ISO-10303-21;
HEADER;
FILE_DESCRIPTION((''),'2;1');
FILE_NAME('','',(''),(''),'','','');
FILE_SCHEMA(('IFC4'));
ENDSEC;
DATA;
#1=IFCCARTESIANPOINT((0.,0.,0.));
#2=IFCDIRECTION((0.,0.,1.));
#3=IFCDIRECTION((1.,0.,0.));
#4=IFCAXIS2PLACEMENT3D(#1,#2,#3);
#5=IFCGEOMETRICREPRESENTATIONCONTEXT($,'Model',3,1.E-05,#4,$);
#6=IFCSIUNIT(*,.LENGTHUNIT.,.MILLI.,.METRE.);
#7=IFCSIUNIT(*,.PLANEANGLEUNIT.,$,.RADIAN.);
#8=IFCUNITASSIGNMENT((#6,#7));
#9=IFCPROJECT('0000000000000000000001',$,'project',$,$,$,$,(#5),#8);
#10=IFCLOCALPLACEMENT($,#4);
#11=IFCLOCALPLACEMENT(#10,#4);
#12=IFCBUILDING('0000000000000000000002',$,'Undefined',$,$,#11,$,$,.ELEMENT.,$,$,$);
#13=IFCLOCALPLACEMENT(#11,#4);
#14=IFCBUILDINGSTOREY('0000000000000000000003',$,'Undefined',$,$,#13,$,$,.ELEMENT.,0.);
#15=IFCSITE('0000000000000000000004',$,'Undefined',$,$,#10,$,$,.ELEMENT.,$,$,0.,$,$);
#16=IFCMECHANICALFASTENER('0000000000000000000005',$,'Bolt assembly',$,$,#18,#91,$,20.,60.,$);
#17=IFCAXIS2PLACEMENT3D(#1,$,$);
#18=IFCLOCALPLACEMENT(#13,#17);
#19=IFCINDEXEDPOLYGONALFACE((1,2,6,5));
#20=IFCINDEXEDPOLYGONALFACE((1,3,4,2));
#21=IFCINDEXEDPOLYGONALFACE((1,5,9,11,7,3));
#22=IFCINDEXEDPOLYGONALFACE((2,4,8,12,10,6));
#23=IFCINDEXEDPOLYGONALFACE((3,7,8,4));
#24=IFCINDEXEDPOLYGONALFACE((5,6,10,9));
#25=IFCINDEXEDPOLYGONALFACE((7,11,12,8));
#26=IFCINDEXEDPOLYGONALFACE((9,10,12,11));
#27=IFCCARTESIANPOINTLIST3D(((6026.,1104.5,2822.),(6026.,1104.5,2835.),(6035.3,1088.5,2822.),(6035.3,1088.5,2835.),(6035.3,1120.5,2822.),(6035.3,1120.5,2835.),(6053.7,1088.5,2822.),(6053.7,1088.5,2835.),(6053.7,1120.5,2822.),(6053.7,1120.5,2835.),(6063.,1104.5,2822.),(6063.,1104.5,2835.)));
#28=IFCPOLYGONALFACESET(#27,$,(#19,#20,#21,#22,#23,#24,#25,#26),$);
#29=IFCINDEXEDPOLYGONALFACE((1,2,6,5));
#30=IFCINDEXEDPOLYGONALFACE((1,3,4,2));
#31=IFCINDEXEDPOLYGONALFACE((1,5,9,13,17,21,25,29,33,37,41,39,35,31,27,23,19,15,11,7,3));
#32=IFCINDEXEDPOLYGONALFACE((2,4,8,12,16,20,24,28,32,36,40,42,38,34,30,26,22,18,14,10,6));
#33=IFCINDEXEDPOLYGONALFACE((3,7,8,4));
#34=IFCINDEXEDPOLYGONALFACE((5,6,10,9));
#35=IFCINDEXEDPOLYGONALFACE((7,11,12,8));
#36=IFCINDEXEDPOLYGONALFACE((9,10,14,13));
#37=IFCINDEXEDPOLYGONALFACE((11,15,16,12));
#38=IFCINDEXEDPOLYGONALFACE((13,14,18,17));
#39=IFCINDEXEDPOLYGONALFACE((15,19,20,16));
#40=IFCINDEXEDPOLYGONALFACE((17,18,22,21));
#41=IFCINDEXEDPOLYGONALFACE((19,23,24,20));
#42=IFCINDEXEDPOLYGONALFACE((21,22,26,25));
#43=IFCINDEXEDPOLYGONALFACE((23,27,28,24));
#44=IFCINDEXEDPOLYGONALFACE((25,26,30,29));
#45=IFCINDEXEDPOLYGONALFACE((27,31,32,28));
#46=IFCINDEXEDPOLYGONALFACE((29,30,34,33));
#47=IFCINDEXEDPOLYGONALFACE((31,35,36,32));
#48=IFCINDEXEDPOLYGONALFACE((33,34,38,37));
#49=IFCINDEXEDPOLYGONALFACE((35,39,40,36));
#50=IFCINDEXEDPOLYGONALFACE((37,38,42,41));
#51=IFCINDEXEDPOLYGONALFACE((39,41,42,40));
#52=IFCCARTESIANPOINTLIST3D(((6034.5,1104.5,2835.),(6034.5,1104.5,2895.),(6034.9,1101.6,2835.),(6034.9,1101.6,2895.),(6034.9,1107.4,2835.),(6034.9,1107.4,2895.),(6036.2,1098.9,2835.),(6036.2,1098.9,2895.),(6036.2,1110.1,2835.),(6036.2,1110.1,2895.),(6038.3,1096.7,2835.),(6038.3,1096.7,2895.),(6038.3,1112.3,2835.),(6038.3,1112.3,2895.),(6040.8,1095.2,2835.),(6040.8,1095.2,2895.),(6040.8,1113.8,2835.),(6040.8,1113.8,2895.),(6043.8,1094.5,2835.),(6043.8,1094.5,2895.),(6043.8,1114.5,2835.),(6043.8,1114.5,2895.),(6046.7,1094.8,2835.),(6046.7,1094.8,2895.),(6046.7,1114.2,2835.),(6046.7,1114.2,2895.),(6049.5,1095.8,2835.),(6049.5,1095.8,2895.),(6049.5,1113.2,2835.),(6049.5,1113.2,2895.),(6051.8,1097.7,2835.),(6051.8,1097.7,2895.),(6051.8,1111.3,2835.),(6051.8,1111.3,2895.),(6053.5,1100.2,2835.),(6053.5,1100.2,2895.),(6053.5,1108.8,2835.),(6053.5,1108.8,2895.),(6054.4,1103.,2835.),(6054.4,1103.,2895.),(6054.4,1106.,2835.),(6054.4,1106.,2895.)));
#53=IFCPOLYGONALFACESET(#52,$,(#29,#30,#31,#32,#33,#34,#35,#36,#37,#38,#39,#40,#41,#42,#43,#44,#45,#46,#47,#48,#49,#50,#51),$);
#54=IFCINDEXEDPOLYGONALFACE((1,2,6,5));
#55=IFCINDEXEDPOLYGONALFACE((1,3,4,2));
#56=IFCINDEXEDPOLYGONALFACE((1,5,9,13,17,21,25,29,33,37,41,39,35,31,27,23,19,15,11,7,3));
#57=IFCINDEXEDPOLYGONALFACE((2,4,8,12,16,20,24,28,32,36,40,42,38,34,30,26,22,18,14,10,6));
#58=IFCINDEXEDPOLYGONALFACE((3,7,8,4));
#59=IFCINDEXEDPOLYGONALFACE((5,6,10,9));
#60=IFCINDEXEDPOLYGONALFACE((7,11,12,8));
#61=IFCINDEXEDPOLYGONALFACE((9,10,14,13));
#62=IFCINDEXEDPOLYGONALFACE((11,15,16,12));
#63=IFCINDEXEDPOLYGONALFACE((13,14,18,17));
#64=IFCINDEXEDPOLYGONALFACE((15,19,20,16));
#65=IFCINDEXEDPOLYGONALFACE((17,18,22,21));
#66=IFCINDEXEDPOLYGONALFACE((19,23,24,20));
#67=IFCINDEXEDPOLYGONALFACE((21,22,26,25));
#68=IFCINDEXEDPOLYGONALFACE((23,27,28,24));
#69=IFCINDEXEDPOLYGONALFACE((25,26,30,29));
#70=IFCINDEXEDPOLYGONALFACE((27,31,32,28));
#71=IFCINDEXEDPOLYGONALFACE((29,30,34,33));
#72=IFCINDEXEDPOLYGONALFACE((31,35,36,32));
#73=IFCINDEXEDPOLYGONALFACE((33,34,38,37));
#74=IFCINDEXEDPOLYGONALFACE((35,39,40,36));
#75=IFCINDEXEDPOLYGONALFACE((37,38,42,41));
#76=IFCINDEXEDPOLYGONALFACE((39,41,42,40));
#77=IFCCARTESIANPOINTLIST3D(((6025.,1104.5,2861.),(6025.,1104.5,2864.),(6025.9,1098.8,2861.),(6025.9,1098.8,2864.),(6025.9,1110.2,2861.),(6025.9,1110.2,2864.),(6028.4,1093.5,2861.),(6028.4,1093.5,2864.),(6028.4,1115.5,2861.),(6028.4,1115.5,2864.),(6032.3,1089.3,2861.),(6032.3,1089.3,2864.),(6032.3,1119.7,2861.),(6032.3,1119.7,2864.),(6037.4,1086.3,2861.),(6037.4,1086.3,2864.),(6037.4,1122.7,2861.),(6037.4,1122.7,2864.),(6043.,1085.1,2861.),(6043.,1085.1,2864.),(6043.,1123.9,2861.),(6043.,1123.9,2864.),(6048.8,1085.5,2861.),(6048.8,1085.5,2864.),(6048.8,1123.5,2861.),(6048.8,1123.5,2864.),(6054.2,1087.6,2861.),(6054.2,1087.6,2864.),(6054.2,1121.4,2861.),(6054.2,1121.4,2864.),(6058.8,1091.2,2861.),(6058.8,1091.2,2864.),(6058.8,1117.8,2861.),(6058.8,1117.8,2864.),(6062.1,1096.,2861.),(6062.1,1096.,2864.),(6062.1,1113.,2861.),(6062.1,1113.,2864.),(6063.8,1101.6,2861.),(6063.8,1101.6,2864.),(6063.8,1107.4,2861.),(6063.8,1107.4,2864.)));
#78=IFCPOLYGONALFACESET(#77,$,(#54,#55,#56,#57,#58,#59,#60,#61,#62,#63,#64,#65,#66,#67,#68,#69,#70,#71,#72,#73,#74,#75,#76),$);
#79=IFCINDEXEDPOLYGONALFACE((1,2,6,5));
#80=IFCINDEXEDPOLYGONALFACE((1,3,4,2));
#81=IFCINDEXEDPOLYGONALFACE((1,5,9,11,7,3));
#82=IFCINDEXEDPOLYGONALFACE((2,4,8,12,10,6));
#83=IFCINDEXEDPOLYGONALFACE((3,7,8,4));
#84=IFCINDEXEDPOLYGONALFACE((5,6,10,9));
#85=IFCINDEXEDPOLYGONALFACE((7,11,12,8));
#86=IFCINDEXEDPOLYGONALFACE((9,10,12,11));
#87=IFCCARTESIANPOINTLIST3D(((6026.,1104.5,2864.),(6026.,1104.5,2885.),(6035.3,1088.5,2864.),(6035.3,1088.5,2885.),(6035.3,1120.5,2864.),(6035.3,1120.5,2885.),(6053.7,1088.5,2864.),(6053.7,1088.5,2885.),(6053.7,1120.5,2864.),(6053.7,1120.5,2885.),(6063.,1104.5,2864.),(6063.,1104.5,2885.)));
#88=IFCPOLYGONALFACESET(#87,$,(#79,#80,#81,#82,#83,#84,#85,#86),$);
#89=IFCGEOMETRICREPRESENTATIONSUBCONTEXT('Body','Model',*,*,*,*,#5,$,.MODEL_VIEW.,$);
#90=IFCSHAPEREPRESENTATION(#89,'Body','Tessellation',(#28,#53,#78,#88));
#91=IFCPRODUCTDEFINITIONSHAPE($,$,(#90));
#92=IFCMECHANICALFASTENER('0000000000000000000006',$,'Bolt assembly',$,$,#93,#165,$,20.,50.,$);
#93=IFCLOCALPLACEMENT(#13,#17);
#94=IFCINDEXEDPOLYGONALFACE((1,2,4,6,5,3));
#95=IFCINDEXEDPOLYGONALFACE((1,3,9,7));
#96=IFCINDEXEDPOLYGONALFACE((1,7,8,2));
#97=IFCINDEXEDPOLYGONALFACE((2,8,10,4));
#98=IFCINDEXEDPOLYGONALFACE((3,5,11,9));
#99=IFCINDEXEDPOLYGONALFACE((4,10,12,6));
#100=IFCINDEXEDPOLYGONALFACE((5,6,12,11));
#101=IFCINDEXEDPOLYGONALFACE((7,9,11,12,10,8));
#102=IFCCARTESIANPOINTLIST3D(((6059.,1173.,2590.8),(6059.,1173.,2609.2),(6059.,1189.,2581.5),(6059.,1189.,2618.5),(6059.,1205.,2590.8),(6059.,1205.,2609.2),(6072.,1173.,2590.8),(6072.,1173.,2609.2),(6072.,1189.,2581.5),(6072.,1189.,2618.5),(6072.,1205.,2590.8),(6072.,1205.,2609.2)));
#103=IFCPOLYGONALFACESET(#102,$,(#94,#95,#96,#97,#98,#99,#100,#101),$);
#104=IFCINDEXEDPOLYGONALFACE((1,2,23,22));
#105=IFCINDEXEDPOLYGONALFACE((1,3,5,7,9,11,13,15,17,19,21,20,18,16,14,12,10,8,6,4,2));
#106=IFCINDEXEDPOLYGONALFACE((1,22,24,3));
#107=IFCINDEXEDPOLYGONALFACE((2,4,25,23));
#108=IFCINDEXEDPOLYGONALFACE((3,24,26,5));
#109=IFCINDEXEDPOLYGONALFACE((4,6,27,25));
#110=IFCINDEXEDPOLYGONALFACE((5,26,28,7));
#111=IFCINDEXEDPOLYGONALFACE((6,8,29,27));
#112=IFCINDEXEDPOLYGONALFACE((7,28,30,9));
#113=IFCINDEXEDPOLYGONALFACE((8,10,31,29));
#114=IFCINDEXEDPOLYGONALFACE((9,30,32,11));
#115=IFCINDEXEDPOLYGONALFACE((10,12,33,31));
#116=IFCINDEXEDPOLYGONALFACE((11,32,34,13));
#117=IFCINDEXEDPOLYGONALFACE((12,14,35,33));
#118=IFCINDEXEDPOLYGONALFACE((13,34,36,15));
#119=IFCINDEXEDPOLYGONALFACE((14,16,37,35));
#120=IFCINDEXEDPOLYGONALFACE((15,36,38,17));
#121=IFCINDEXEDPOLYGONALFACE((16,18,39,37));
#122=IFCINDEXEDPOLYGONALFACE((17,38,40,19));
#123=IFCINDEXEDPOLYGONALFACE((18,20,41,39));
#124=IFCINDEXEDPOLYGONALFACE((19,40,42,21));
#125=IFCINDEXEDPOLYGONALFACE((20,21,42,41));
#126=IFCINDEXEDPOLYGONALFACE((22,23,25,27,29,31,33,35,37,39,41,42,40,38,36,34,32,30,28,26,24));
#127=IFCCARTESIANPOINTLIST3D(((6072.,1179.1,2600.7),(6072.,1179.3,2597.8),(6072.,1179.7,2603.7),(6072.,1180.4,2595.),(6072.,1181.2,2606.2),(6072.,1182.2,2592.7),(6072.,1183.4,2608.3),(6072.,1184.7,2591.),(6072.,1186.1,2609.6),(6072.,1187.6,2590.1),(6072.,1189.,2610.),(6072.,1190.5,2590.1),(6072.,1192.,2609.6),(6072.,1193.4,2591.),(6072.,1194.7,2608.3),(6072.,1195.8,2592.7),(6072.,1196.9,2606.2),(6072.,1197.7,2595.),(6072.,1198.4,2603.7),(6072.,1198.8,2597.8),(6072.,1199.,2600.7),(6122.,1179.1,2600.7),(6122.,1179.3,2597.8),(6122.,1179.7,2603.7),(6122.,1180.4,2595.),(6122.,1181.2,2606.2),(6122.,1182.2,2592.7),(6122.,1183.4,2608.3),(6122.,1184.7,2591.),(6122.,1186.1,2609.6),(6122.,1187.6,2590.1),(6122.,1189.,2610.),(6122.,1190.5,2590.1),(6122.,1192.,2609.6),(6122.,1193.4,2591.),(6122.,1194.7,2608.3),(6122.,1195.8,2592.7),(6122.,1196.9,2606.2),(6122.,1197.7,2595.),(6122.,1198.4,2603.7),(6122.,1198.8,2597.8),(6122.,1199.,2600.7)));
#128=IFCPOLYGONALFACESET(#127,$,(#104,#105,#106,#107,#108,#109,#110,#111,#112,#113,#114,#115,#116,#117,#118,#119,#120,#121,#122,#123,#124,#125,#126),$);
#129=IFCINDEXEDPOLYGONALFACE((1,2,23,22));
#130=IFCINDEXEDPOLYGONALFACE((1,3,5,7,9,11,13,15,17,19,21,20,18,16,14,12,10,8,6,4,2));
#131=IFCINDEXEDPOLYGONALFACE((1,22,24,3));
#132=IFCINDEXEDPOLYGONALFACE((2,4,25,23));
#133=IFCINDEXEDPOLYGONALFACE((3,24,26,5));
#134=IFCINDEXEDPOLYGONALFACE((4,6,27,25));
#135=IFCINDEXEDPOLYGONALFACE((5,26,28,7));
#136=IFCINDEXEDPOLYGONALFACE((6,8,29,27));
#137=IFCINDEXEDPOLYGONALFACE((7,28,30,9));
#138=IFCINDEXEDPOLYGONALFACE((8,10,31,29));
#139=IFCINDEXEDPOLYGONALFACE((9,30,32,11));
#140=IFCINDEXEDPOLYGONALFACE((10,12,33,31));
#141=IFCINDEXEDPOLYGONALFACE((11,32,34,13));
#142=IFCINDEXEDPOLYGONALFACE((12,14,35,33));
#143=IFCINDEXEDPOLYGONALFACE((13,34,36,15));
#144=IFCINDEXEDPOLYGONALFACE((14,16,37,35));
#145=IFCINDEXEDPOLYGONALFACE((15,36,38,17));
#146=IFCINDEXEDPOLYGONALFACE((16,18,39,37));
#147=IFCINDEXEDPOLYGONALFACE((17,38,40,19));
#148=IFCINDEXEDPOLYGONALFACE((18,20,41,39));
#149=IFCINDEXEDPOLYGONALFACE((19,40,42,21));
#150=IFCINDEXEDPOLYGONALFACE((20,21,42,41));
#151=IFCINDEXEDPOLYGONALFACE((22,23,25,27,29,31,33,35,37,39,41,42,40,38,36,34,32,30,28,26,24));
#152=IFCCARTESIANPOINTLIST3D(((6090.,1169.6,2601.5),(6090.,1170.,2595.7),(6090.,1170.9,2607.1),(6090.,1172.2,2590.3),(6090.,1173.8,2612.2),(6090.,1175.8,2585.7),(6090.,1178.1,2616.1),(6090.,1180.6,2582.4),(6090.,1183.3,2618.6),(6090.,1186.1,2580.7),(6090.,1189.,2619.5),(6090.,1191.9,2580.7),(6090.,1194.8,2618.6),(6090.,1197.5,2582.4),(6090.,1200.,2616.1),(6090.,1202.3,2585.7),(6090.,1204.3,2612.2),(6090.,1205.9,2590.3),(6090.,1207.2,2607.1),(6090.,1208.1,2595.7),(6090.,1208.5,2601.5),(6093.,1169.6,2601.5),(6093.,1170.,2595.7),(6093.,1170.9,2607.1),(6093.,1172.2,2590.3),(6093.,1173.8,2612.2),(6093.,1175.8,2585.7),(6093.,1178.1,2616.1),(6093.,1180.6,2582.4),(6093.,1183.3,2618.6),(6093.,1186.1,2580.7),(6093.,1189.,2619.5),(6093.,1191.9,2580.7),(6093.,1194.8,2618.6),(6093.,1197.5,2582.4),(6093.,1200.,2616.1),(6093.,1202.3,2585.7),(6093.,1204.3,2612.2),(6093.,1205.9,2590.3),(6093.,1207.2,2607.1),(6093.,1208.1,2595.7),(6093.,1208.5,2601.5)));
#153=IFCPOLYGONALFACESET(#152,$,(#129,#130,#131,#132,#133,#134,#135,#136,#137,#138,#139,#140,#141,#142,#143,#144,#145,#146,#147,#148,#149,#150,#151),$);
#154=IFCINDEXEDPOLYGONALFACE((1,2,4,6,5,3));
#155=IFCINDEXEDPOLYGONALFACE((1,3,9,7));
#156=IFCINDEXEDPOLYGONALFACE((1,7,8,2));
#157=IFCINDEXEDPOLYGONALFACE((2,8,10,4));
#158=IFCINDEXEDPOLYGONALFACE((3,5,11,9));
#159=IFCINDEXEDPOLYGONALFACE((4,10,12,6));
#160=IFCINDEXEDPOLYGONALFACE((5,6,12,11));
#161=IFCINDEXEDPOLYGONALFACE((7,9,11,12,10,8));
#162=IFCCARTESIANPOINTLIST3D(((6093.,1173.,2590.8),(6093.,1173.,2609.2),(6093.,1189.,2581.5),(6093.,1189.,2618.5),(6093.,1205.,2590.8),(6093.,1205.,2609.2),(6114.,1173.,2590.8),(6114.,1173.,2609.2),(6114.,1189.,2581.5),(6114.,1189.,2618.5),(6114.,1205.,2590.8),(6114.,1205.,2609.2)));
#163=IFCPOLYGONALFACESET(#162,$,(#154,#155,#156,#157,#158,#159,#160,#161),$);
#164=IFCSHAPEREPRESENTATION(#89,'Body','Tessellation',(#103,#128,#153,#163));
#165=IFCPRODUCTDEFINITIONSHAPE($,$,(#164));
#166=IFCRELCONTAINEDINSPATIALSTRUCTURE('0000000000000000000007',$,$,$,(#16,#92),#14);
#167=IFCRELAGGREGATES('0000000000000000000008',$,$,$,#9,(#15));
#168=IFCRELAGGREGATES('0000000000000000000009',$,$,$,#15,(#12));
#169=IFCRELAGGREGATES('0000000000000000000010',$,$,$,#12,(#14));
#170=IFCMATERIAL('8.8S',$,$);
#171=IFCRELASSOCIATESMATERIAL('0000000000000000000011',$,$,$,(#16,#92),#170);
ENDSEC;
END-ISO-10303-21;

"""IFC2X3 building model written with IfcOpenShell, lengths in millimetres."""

from ifc_helpers import new_model, si_unit, frame, origin_with_axes, origin_2d_with_axis, place, context, subcontext, project, spatial, polyline, circle, outline, extrude, source, transform, mapped, material, element, save


model = new_model("IFC2X3")

# Units and contexts
model_context = context("Model", 3, precision=1e-05, world=origin_with_axes())
body_context = subcontext(model_context, "Body", "Model", "MODEL_VIEW")
ifc_project = project(units=[si_unit("LENGTHUNIT", "METRE", prefix="MILLI"), si_unit("PLANEANGLEUNIT", "RADIAN")], contexts=[model_context])

# Site, building, storey
site_placement = place(None, origin_with_axes())
site = spatial("IfcSite", under=ifc_project, at=site_placement, Name="Undefined", CompositionType="ELEMENT", RefElevation=0.0)
building_placement = place(site_placement, origin_with_axes())
building = spatial("IfcBuilding", under=site, at=building_placement, Name="Undefined", CompositionType="ELEMENT")
storey_placement = place(building_placement, origin_with_axes())
storey = spatial("IfcBuildingStorey", under=building, at=storey_placement, Name="Undefined", CompositionType="ELEMENT", Elevation=0.0)

# Mechanical fasteners
ifc_material_1 = material(Name="8.8S")
shared_shape_1 = source(origin_with_axes(), body_context, "Body", "SweptSolid", [
    extrude(outline(polyline([(18.5, 0.0), (9.2, 16.0), (-9.2, 16.0), (-18.5, 0.0), (-9.2, -16.0), (9.2, -16.0), (18.5, 0.0)])), frame((0.0, -23.0, 0.0), z_axis=(0.0, 1.0, 0.0), x_axis=(1.0, 0.0, 0.0)), (0.0, 0.0, 1.0), 13.0),
    extrude(circle(Radius=10.0, at=origin_2d_with_axis()), frame((0.0, -10.0, 0.0), z_axis=(0.0, 1.0, 0.0), x_axis=(1.0, 0.0, 0.0)), (0.0, 0.0, 1.0), 60.0),
    extrude(circle(Radius=19.5, at=origin_2d_with_axis()), frame((0.0, 16.0, 0.0), z_axis=(0.0, 1.0, 0.0), x_axis=(1.0, 0.0, 0.0)), (0.0, 0.0, 1.0), 3.0),
    extrude(outline(polyline([(18.5, 0.0), (9.2, 16.0), (-9.2, 16.0), (-18.5, 0.0), (-9.2, -16.0), (9.2, -16.0), (18.5, 0.0)])), frame((0.0, 19.0, 0.0), z_axis=(0.0, 1.0, 0.0), x_axis=(1.0, 0.0, 0.0)), (0.0, 0.0, 1.0), 21.0),
])
for number, where, z_axis, x_axis, name in (
    (1, (6044.5, 1104.5, 2845.0), (0.0, 1.0, 0.0), (-1.0, 0.0, 0.0), "Bolt assembly"),
):
    element("IfcMechanicalFastener", number, at=place(storey_placement, frame(where, z_axis=z_axis, x_axis=x_axis)), inside=storey, material=ifc_material_1, Name=name, NominalDiameter=20.0, NominalLength=60.0, context=body_context, shape_type="MappedRepresentation", body=[
        mapped(shared_shape_1, transform((0.0, 0.0, 0.0))),
    ])
shared_shape_2 = source(origin_with_axes(), body_context, "Body", "SweptSolid", [
    extrude(outline(polyline([(18.5, 0.0), (9.2, 16.0), (-9.2, 16.0), (-18.5, 0.0), (-9.2, -16.0), (9.2, -16.0), (18.5, 0.0)])), frame((0.0, -23.0, 0.0), z_axis=(0.0, 1.0, 0.0), x_axis=(1.0, 0.0, 0.0)), (0.0, 0.0, 1.0), 13.0),
    extrude(circle(Radius=10.0, at=origin_2d_with_axis()), frame((0.0, -10.0, 0.0), z_axis=(0.0, 1.0, 0.0), x_axis=(1.0, 0.0, 0.0)), (0.0, 0.0, 1.0), 50.0),
    extrude(circle(Radius=19.5, at=origin_2d_with_axis()), frame((0.0, 8.0, 0.0), z_axis=(0.0, 1.0, 0.0), x_axis=(1.0, 0.0, 0.0)), (0.0, 0.0, 1.0), 3.0),
    extrude(outline(polyline([(18.5, 0.0), (9.2, 16.0), (-9.2, 16.0), (-18.5, 0.0), (-9.2, -16.0), (9.2, -16.0), (18.5, 0.0)])), frame((0.0, 11.0, 0.0), z_axis=(0.0, 1.0, 0.0), x_axis=(1.0, 0.0, 0.0)), (0.0, 0.0, 1.0), 21.0),
])
for number, where, z_axis, x_axis, name in (
    (2, (6082.0, 1189.0, 2600.0), (0.0, 1.0, 0.0), (-0.000022, 0.0, 1.0), "Bolt assembly"),
):
    element("IfcMechanicalFastener", number, at=place(storey_placement, frame(where, z_axis=z_axis, x_axis=x_axis)), inside=storey, material=ifc_material_1, Name=name, NominalDiameter=20.0, NominalLength=50.0, context=body_context, shape_type="MappedRepresentation", body=[
        mapped(shared_shape_2, transform((0.0, 0.0, 0.0))),
    ])

save(model, "model.ifc")
